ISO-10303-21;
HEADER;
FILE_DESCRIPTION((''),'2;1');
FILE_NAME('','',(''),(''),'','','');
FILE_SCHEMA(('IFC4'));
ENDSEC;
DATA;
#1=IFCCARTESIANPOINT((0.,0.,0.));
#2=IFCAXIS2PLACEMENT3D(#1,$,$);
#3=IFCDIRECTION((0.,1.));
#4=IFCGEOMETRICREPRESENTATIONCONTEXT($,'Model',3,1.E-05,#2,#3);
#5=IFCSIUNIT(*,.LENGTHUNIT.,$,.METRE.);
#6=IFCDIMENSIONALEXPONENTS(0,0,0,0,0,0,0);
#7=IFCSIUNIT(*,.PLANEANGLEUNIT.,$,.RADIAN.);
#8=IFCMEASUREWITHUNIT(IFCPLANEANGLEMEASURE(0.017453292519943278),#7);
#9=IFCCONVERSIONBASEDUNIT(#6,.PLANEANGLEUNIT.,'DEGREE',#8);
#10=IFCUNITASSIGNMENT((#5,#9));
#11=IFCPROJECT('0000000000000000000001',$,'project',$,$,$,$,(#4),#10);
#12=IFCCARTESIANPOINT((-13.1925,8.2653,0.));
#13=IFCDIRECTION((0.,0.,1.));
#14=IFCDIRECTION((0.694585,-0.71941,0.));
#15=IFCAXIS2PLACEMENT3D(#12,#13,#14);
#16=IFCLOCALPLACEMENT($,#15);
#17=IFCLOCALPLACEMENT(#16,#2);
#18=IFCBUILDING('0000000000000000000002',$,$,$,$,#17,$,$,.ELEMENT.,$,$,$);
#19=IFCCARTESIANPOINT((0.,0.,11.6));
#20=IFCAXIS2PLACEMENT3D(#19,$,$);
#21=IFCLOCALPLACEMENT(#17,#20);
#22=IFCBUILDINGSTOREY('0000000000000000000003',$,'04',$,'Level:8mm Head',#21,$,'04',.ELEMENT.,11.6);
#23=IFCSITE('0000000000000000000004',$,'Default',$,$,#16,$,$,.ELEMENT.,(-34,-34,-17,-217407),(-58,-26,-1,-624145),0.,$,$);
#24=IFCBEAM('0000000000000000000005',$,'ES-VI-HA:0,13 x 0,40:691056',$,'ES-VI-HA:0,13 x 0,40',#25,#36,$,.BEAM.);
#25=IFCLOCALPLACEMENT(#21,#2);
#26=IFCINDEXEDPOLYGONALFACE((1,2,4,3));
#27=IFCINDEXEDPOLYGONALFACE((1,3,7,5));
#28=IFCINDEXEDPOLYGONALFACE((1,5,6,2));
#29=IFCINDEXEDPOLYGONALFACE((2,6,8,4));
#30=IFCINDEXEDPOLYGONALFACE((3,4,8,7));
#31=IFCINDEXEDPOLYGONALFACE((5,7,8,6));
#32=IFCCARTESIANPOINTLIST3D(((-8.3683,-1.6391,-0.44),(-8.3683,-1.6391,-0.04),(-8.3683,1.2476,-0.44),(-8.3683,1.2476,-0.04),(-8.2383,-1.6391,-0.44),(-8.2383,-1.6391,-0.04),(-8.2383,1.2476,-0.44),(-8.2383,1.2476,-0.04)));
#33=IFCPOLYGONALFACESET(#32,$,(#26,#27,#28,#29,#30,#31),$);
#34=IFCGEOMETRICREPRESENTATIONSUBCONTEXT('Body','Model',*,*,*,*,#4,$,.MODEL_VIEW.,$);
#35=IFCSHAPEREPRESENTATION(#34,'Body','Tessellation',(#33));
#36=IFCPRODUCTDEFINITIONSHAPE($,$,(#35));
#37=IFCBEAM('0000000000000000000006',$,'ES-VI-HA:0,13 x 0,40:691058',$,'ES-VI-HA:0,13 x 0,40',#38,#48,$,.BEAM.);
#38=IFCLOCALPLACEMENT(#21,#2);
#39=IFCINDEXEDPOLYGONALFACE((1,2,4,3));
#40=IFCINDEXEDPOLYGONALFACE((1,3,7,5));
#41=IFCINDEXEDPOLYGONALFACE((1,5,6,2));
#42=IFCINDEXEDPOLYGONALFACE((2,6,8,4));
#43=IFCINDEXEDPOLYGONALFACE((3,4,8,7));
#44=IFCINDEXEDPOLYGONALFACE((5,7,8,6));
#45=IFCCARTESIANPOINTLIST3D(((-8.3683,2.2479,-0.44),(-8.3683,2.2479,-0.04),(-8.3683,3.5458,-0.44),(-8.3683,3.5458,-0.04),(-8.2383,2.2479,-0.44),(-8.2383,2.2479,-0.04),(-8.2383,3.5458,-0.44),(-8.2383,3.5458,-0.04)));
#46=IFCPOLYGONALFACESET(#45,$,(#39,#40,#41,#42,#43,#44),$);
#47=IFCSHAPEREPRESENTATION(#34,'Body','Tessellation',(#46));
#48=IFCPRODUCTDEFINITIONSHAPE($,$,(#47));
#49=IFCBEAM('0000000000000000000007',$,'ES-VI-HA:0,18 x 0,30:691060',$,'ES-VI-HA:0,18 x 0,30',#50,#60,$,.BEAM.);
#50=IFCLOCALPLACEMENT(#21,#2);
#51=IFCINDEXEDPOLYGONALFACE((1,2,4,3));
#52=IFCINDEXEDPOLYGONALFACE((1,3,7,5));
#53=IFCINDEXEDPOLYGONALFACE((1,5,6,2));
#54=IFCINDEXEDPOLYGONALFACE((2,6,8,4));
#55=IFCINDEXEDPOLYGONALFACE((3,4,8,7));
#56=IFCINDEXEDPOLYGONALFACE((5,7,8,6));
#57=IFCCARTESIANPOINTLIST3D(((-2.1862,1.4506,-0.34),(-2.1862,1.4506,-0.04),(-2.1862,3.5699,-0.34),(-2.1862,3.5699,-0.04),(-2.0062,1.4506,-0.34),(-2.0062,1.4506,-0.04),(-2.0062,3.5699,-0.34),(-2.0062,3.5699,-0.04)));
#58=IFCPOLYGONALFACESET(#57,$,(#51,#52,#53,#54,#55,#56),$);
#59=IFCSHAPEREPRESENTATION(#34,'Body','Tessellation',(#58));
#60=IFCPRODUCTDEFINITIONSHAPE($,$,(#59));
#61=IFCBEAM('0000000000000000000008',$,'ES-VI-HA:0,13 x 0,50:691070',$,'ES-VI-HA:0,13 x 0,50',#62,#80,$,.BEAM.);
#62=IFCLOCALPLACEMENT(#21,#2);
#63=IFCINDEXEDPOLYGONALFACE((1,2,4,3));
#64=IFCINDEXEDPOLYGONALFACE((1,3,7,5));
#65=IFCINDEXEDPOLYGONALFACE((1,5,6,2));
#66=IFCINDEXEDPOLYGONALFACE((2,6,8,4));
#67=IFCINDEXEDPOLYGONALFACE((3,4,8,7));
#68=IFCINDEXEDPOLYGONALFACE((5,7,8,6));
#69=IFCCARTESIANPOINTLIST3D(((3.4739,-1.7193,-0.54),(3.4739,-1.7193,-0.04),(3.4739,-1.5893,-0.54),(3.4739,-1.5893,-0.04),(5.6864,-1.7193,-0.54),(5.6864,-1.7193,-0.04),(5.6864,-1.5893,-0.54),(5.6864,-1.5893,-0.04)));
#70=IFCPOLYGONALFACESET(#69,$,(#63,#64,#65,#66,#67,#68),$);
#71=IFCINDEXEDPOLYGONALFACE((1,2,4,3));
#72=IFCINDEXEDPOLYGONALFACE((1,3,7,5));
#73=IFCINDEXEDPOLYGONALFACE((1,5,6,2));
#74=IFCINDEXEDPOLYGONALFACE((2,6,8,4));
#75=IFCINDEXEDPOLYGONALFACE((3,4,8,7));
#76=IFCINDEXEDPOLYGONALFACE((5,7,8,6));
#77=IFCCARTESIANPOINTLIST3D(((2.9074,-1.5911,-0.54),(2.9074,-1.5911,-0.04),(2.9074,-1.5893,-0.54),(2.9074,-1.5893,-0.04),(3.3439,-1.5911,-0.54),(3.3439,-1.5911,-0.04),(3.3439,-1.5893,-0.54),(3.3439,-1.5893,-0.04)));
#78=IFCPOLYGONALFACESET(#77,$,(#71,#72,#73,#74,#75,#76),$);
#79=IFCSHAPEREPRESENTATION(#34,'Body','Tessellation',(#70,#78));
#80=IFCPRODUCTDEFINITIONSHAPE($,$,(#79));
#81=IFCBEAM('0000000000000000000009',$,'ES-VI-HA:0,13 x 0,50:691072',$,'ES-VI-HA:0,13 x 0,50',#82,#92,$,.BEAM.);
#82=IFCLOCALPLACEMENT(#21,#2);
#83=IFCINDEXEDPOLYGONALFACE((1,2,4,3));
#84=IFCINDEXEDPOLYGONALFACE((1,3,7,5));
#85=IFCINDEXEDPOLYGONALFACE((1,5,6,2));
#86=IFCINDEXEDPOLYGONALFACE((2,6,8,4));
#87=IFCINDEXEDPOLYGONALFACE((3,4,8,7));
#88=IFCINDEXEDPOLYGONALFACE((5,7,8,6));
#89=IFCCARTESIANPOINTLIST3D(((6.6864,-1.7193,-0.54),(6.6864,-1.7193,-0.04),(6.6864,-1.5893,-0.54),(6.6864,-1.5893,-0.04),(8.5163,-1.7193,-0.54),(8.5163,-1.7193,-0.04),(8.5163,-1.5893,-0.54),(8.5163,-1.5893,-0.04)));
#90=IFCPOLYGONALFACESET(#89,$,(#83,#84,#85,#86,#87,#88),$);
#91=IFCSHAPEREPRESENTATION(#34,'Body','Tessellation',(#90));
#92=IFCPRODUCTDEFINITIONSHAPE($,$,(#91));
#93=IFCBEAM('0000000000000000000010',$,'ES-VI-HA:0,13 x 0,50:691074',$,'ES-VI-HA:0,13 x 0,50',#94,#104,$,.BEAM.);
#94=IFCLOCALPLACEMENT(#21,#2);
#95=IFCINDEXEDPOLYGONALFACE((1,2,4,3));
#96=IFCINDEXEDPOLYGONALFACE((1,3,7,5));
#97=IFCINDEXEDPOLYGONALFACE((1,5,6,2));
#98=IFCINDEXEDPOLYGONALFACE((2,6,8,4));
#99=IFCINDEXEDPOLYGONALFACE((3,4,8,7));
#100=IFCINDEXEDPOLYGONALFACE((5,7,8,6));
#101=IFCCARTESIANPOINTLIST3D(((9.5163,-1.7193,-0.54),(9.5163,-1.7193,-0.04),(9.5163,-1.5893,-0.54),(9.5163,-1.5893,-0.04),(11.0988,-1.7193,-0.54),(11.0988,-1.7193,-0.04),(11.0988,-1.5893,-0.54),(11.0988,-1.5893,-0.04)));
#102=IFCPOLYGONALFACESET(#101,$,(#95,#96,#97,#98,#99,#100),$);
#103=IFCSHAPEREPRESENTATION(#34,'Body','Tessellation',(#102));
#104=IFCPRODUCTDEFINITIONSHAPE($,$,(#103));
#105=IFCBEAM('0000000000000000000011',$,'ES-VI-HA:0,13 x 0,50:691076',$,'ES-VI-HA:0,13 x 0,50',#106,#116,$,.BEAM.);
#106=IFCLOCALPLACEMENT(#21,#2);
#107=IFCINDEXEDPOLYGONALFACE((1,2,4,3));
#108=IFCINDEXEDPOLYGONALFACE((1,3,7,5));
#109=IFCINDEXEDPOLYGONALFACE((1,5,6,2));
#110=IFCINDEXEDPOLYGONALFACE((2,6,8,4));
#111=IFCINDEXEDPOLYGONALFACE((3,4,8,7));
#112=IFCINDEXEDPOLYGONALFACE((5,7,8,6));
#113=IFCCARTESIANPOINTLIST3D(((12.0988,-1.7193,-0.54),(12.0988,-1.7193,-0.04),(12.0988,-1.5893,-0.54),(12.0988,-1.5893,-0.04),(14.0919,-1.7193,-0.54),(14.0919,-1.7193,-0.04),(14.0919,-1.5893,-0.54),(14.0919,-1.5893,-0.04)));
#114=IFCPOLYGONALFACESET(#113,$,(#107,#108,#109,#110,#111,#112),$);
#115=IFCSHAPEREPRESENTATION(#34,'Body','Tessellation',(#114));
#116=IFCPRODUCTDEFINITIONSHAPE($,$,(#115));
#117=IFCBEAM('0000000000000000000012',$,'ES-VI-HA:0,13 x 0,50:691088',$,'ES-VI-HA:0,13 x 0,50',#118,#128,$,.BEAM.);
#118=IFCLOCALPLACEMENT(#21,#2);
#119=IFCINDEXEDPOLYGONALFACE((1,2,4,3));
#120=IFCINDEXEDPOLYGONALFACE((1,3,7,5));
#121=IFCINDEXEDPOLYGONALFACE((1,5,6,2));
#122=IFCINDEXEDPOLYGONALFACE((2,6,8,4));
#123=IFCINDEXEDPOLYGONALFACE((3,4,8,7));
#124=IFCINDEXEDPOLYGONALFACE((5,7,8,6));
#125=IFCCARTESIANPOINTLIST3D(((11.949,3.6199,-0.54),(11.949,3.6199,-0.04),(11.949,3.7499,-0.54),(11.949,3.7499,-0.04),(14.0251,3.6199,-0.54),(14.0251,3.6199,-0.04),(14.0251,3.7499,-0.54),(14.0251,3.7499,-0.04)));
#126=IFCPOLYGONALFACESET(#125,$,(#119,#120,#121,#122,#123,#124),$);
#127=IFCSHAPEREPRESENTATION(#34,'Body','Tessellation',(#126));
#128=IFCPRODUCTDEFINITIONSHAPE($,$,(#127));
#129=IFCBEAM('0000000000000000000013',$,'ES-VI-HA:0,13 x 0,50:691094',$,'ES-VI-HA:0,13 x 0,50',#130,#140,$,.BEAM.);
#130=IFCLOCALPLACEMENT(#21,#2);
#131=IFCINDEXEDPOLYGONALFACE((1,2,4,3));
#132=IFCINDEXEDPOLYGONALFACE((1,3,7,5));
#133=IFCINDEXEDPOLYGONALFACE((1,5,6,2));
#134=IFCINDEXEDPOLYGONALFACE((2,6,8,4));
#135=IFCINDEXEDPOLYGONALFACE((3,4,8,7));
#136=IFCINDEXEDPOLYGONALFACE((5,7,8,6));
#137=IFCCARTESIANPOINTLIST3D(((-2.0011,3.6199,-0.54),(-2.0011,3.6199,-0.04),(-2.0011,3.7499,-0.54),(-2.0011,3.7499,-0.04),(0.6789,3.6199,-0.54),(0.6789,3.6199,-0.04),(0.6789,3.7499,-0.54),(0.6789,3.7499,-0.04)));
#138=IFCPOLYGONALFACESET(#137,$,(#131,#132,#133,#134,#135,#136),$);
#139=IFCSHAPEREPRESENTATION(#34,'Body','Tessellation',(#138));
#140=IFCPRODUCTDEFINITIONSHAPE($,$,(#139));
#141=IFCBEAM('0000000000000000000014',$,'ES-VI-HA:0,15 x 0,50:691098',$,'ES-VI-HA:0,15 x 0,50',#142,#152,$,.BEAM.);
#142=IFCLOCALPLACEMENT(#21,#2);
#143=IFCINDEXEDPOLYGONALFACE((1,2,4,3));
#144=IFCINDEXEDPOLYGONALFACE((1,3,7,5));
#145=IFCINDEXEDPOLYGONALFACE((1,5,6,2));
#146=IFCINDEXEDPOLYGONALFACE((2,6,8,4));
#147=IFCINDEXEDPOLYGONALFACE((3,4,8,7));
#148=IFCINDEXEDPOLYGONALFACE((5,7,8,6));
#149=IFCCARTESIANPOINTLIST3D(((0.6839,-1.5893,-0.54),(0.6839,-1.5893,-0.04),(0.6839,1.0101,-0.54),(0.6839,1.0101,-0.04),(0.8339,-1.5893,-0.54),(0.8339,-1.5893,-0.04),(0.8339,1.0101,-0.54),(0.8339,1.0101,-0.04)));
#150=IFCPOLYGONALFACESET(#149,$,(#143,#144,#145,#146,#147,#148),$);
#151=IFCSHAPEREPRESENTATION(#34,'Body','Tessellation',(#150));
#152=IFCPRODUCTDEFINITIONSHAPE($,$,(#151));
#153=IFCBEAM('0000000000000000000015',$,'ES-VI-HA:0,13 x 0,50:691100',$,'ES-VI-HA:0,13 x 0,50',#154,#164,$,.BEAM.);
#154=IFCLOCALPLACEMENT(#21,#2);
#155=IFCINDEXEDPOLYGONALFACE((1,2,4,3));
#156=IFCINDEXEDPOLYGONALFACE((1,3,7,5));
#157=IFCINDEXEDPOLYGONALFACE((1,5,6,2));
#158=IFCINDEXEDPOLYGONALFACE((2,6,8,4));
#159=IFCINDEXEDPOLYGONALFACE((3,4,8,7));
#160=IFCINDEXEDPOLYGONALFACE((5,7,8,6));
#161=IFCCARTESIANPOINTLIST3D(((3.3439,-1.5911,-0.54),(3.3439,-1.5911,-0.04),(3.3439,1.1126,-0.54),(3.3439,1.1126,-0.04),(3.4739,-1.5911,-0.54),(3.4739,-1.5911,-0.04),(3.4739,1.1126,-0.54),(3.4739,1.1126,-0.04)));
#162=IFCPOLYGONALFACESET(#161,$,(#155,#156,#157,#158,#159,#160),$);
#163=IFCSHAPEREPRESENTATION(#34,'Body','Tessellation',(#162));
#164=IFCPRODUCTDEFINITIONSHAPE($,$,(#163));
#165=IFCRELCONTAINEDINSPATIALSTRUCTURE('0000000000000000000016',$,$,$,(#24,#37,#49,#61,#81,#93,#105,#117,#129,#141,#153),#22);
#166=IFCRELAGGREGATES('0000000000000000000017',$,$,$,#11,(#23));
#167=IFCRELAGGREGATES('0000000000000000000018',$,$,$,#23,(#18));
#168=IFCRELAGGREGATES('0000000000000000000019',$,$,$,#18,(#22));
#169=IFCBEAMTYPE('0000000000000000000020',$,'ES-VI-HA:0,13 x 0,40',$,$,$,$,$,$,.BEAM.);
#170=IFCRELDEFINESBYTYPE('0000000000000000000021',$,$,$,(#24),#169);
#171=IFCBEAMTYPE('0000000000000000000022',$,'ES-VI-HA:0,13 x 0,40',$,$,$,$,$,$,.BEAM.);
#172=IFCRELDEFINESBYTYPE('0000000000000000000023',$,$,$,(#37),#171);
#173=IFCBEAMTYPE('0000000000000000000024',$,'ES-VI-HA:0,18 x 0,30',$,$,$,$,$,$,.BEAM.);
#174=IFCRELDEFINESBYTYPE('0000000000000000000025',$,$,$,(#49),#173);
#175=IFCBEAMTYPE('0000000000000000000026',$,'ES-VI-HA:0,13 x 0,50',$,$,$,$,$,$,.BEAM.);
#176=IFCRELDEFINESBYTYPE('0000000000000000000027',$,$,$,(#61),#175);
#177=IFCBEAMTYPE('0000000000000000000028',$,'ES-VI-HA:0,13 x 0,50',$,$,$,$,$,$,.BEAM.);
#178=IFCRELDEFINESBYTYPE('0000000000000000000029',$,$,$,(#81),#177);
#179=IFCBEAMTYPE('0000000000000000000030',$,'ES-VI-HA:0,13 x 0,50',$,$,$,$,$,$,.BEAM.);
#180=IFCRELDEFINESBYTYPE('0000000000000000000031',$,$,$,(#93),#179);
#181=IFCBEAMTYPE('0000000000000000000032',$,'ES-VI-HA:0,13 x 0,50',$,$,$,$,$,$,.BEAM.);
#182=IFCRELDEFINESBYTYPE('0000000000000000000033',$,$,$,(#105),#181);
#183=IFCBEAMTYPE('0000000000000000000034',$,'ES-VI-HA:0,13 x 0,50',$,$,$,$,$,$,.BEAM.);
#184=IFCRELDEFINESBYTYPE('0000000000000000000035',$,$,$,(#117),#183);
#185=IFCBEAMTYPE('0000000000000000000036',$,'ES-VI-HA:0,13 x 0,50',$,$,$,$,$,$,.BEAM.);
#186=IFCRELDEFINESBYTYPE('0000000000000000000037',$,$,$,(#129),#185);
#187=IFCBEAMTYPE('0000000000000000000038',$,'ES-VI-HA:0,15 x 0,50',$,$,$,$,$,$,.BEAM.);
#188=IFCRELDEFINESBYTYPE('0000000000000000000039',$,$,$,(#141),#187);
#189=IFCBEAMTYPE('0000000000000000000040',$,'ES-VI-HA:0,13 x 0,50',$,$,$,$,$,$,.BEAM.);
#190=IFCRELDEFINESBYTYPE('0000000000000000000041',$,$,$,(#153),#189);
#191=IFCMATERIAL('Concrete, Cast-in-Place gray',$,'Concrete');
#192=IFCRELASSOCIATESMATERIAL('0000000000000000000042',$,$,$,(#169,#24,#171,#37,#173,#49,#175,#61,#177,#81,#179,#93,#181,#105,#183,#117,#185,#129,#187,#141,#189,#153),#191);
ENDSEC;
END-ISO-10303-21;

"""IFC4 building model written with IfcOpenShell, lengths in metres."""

from ifc_helpers import new_model, entity, si_unit, converted_unit, direction, frame, origin, place, context, subcontext, project, spatial, indexed_curve, outline, extrude, source, transform, mapped, material, type_object, type_shapes, element, save


model = new_model("IFC4")

# Units and contexts
model_context = context("Model", 3, precision=1e-05, world=origin(), true_north=direction((0.0, 1.0)))
body_context = subcontext(model_context, "Body", "Model", "MODEL_VIEW")
ifc_project = project(units=[si_unit("LENGTHUNIT", "METRE"), converted_unit("PLANEANGLEUNIT", "DEGREE", entity("IfcPlaneAngleMeasure", 0.017453292519943278), si_unit("PLANEANGLEUNIT", "RADIAN"), dimensions=[0, 0, 0, 0, 0, 0, 0])], contexts=[model_context])

# Site, building, storey
site_placement = place(None, frame((-13.1925, 8.2653, 0.0), z_axis=(0.0, 0.0, 1.0), x_axis=(0.694585, -0.71941, 0.0)))
site = spatial("IfcSite", under=ifc_project, at=site_placement, Name="Default", CompositionType="ELEMENT", RefLatitude=(-34, -34, -17, -217407), RefLongitude=(-58, -26, -1, -624145), RefElevation=0.0)
building_placement = place(site_placement, origin())
building = spatial("IfcBuilding", under=site, at=building_placement, CompositionType="ELEMENT")
storey_placement = place(building_placement, frame((0.0, 0.0, 11.6)))
storey = spatial("IfcBuildingStorey", under=building, at=storey_placement, Name="04", ObjectType="Level:8mm Head", LongName="04", CompositionType="ELEMENT", Elevation=11.6)

# Beams
ifc_material = material(Name="Concrete, Cast-in-Place gray", Category="Concrete")
beam_type_1 = type_object("IfcBeamType", Name="ES-VI-HA:0,13 x 0,40", PredefinedType="BEAM", material=ifc_material)
shared_shape_1 = source(origin(), body_context, "Body", "SweptSolid", [
    extrude(outline(indexed_curve([(-0.065, -0.2), (0.065, -0.2), (0.065, 0.2), (-0.065, 0.2), (-0.065, -0.2)], self_intersect=False)), frame((-8.3033, -1.6391, 11.36), z_axis=(0.0, 1.0, 0.0), x_axis=(-1.0, 0.0, 0.0)), (0.0, 0.0, 1.0), 2.8867),
])
type_shapes(beam_type_1, [shared_shape_1])
beam_1_placement = place(storey_placement, frame((0.0, 0.0, -11.6)))
element("IfcBeam", 1, at=beam_1_placement, inside=storey, type_object=beam_type_1, material=ifc_material, Name="ES-VI-HA:0,13 x 0,40:691056", ObjectType="ES-VI-HA:0,13 x 0,40", PredefinedType="BEAM", context=body_context, shape_type="MappedRepresentation", body=[
    mapped(shared_shape_1, transform((0.0, 0.0, 0.0), scale=1.0)),
])
beam_type_2 = type_object("IfcBeamType", Name="ES-VI-HA:0,13 x 0,40", PredefinedType="BEAM", material=ifc_material)
shared_shape_2 = source(origin(), body_context, "Body", "SweptSolid", [
    extrude(outline(indexed_curve([(-0.065, -0.2), (0.065, -0.2), (0.065, 0.2), (-0.065, 0.2), (-0.065, -0.2)], self_intersect=False)), frame((-8.3033, 2.2479, 11.36), z_axis=(0.0, 1.0, 0.0), x_axis=(-1.0, 0.0, 0.0)), (0.0, 0.0, 1.0), 1.298),
])
type_shapes(beam_type_2, [shared_shape_2])
beam_2_placement = place(storey_placement, frame((0.0, 0.0, -11.6)))
element("IfcBeam", 2, at=beam_2_placement, inside=storey, type_object=beam_type_2, material=ifc_material, Name="ES-VI-HA:0,13 x 0,40:691058", ObjectType="ES-VI-HA:0,13 x 0,40", PredefinedType="BEAM", context=body_context, shape_type="MappedRepresentation", body=[
    mapped(shared_shape_2, transform((0.0, 0.0, 0.0), scale=1.0)),
])
beam_type_3 = type_object("IfcBeamType", Name="ES-VI-HA:0,18 x 0,30", PredefinedType="BEAM", material=ifc_material)
shared_shape_3 = source(origin(), body_context, "Body", "SweptSolid", [
    extrude(outline(indexed_curve([(-0.09, -0.15), (0.09, -0.15), (0.09, 0.15), (-0.09, 0.15), (-0.09, -0.15)], self_intersect=False)), frame((-2.0962, 3.5699, 11.41), z_axis=(0.0, -1.0, 0.0), x_axis=(-1.0, 0.0, 0.0)), (0.0, 0.0, 1.0), 2.1193),
])
type_shapes(beam_type_3, [shared_shape_3])
beam_3_placement = place(storey_placement, frame((0.0, 0.0, -11.6)))
element("IfcBeam", 3, at=beam_3_placement, inside=storey, type_object=beam_type_3, material=ifc_material, Name="ES-VI-HA:0,18 x 0,30:691060", ObjectType="ES-VI-HA:0,18 x 0,30", PredefinedType="BEAM", context=body_context, shape_type="MappedRepresentation", body=[
    mapped(shared_shape_3, transform((0.0, 0.0, 0.0), scale=1.0)),
])
beam_type_4 = type_object("IfcBeamType", Name="ES-VI-HA:0,13 x 0,50", PredefinedType="BEAM", material=ifc_material)
shared_shape_4 = source(origin(), body_context, "Body", "SweptSolid", [
    extrude(outline(indexed_curve([(-0.25, -0.065), (0.25, -0.065), (0.25, 0.065), (-0.25, 0.065), (-0.25, -0.065)], self_intersect=False)), frame((3.4739, -1.6543, 11.31), z_axis=(1.0, 0.0, 0.0), x_axis=(0.0, 0.0, -1.0)), (0.0, 0.0, 1.0), 2.2125),
    extrude(outline(indexed_curve([(-0.25, -0.0009), (0.25, -0.0009), (0.25, 0.0009), (-0.25, 0.0009), (-0.25, -0.0009)], self_intersect=False)), frame((2.9074, -1.5902, 11.31), z_axis=(1.0, 0.0, 0.0), x_axis=(0.0, 0.0, -1.0)), (0.0, 0.0, 1.0), 0.4365),
])
type_shapes(beam_type_4, [shared_shape_4])
beam_4_placement = place(storey_placement, frame((0.0, 0.0, -11.6)))
element("IfcBeam", 4, at=beam_4_placement, inside=storey, type_object=beam_type_4, material=ifc_material, Name="ES-VI-HA:0,13 x 0,50:691070", ObjectType="ES-VI-HA:0,13 x 0,50", PredefinedType="BEAM", context=body_context, shape_type="MappedRepresentation", body=[
    mapped(shared_shape_4, transform((0.0, 0.0, 0.0), scale=1.0)),
])
beam_type_5 = type_object("IfcBeamType", Name="ES-VI-HA:0,13 x 0,50", PredefinedType="BEAM", material=ifc_material)
shared_shape_5 = source(origin(), body_context, "Body", "SweptSolid", [
    extrude(outline(indexed_curve([(-0.25, -0.065), (0.25, -0.065), (0.25, 0.065), (-0.25, 0.065), (-0.25, -0.065)], self_intersect=False)), frame((6.6864, -1.6543, 11.31), z_axis=(1.0, 0.0, 0.0), x_axis=(0.0, 0.0, -1.0)), (0.0, 0.0, 1.0), 1.8299),
])
type_shapes(beam_type_5, [shared_shape_5])
beam_5_placement = place(storey_placement, frame((0.0, 0.0, -11.6)))
element("IfcBeam", 5, at=beam_5_placement, inside=storey, type_object=beam_type_5, material=ifc_material, Name="ES-VI-HA:0,13 x 0,50:691072", ObjectType="ES-VI-HA:0,13 x 0,50", PredefinedType="BEAM", context=body_context, shape_type="MappedRepresentation", body=[
    mapped(shared_shape_5, transform((0.0, 0.0, 0.0), scale=1.0)),
])
beam_type_6 = type_object("IfcBeamType", Name="ES-VI-HA:0,13 x 0,50", PredefinedType="BEAM", material=ifc_material)
shared_shape_6 = source(origin(), body_context, "Body", "SweptSolid", [
    extrude(outline(indexed_curve([(-0.25, -0.065), (0.25, -0.065), (0.25, 0.065), (-0.25, 0.065), (-0.25, -0.065)], self_intersect=False)), frame((9.5163, -1.6543, 11.31), z_axis=(1.0, 0.0, 0.0), x_axis=(0.0, 0.0, -1.0)), (0.0, 0.0, 1.0), 1.5825),
])
type_shapes(beam_type_6, [shared_shape_6])
beam_6_placement = place(storey_placement, frame((0.0, 0.0, -11.6)))
element("IfcBeam", 6, at=beam_6_placement, inside=storey, type_object=beam_type_6, material=ifc_material, Name="ES-VI-HA:0,13 x 0,50:691074", ObjectType="ES-VI-HA:0,13 x 0,50", PredefinedType="BEAM", context=body_context, shape_type="MappedRepresentation", body=[
    mapped(shared_shape_6, transform((0.0, 0.0, 0.0), scale=1.0)),
])
beam_type_7 = type_object("IfcBeamType", Name="ES-VI-HA:0,13 x 0,50", PredefinedType="BEAM", material=ifc_material)
shared_shape_7 = source(origin(), body_context, "Body", "SweptSolid", [
    extrude(outline(indexed_curve([(-0.25, -0.065), (0.25, -0.065), (0.25, 0.065), (-0.25, 0.065), (-0.25, -0.065)], self_intersect=False)), frame((12.0988, -1.6543, 11.31), z_axis=(1.0, 0.0, 0.0), x_axis=(0.0, 0.0, -1.0)), (0.0, 0.0, 1.0), 1.9932),
])
type_shapes(beam_type_7, [shared_shape_7])
beam_7_placement = place(storey_placement, frame((0.0, 0.0, -11.6)))
element("IfcBeam", 7, at=beam_7_placement, inside=storey, type_object=beam_type_7, material=ifc_material, Name="ES-VI-HA:0,13 x 0,50:691076", ObjectType="ES-VI-HA:0,13 x 0,50", PredefinedType="BEAM", context=body_context, shape_type="MappedRepresentation", body=[
    mapped(shared_shape_7, transform((0.0, 0.0, 0.0), scale=1.0)),
])
beam_type_8 = type_object("IfcBeamType", Name="ES-VI-HA:0,13 x 0,50", PredefinedType="BEAM", material=ifc_material)
shared_shape_8 = source(origin(), body_context, "Body", "SweptSolid", [
    extrude(outline(indexed_curve([(-0.25, -0.065), (0.25, -0.065), (0.25, 0.065), (-0.25, 0.065), (-0.25, -0.065)], self_intersect=False)), frame((11.949, 3.6849, 11.31), z_axis=(1.0, 0.0, 0.0), x_axis=(0.0, 0.0, -1.0)), (0.0, 0.0, 1.0), 2.0761),
])
type_shapes(beam_type_8, [shared_shape_8])
beam_8_placement = place(storey_placement, frame((0.0, 0.0, -11.6)))
element("IfcBeam", 8, at=beam_8_placement, inside=storey, type_object=beam_type_8, material=ifc_material, Name="ES-VI-HA:0,13 x 0,50:691088", ObjectType="ES-VI-HA:0,13 x 0,50", PredefinedType="BEAM", context=body_context, shape_type="MappedRepresentation", body=[
    mapped(shared_shape_8, transform((0.0, 0.0, 0.0), scale=1.0)),
])
beam_type_9 = type_object("IfcBeamType", Name="ES-VI-HA:0,13 x 0,50", PredefinedType="BEAM", material=ifc_material)
shared_shape_9 = source(origin(), body_context, "Body", "SweptSolid", [
    extrude(outline(indexed_curve([(-0.25, -0.065), (0.25, -0.065), (0.25, 0.065), (-0.25, 0.065), (-0.25, -0.065)], self_intersect=False)), frame((-2.0011, 3.6849, 11.31), z_axis=(1.0, 0.0, 0.0), x_axis=(0.0, 0.0, -1.0)), (0.0, 0.0, 1.0), 2.68),
])
type_shapes(beam_type_9, [shared_shape_9])
beam_9_placement = place(storey_placement, frame((0.0, 0.0, -11.6)))
element("IfcBeam", 9, at=beam_9_placement, inside=storey, type_object=beam_type_9, material=ifc_material, Name="ES-VI-HA:0,13 x 0,50:691094", ObjectType="ES-VI-HA:0,13 x 0,50", PredefinedType="BEAM", context=body_context, shape_type="MappedRepresentation", body=[
    mapped(shared_shape_9, transform((0.0, 0.0, 0.0), scale=1.0)),
])
beam_type_10 = type_object("IfcBeamType", Name="ES-VI-HA:0,15 x 0,50", PredefinedType="BEAM", material=ifc_material)
shared_shape_10 = source(origin(), body_context, "Body", "SweptSolid", [
    extrude(outline(indexed_curve([(-0.075, -0.25), (0.075, -0.25), (0.075, 0.25), (-0.075, 0.25), (-0.075, -0.25)], self_intersect=False)), frame((0.7589, -1.5893, 11.31), z_axis=(0.0, 1.0, 0.0), x_axis=(-1.0, 0.0, 0.0)), (0.0, 0.0, 1.0), 2.5994),
])
type_shapes(beam_type_10, [shared_shape_10])
beam_10_placement = place(storey_placement, frame((0.0, 0.0, -11.6)))
element("IfcBeam", 10, at=beam_10_placement, inside=storey, type_object=beam_type_10, material=ifc_material, Name="ES-VI-HA:0,15 x 0,50:691098", ObjectType="ES-VI-HA:0,15 x 0,50", PredefinedType="BEAM", context=body_context, shape_type="MappedRepresentation", body=[
    mapped(shared_shape_10, transform((0.0, 0.0, 0.0), scale=1.0)),
])
beam_type_11 = type_object("IfcBeamType", Name="ES-VI-HA:0,13 x 0,50", PredefinedType="BEAM", material=ifc_material)
shared_shape_11 = source(origin(), body_context, "Body", "SweptSolid", [
    extrude(outline(indexed_curve([(-0.065, -0.25), (0.065, -0.25), (0.065, 0.25), (-0.065, 0.25), (-0.065, -0.25)], self_intersect=False)), frame((3.4089, -1.5911, 11.31), z_axis=(0.0, 1.0, 0.0), x_axis=(-1.0, 0.0, 0.0)), (0.0, 0.0, 1.0), 2.7037),
])
type_shapes(beam_type_11, [shared_shape_11])
beam_11_placement = place(storey_placement, frame((0.0, 0.0, -11.6)))
element("IfcBeam", 11, at=beam_11_placement, inside=storey, type_object=beam_type_11, material=ifc_material, Name="ES-VI-HA:0,13 x 0,50:691100", ObjectType="ES-VI-HA:0,13 x 0,50", PredefinedType="BEAM", context=body_context, shape_type="MappedRepresentation", body=[
    mapped(shared_shape_11, transform((0.0, 0.0, 0.0), scale=1.0)),
])

save(model, "model.ifc")
